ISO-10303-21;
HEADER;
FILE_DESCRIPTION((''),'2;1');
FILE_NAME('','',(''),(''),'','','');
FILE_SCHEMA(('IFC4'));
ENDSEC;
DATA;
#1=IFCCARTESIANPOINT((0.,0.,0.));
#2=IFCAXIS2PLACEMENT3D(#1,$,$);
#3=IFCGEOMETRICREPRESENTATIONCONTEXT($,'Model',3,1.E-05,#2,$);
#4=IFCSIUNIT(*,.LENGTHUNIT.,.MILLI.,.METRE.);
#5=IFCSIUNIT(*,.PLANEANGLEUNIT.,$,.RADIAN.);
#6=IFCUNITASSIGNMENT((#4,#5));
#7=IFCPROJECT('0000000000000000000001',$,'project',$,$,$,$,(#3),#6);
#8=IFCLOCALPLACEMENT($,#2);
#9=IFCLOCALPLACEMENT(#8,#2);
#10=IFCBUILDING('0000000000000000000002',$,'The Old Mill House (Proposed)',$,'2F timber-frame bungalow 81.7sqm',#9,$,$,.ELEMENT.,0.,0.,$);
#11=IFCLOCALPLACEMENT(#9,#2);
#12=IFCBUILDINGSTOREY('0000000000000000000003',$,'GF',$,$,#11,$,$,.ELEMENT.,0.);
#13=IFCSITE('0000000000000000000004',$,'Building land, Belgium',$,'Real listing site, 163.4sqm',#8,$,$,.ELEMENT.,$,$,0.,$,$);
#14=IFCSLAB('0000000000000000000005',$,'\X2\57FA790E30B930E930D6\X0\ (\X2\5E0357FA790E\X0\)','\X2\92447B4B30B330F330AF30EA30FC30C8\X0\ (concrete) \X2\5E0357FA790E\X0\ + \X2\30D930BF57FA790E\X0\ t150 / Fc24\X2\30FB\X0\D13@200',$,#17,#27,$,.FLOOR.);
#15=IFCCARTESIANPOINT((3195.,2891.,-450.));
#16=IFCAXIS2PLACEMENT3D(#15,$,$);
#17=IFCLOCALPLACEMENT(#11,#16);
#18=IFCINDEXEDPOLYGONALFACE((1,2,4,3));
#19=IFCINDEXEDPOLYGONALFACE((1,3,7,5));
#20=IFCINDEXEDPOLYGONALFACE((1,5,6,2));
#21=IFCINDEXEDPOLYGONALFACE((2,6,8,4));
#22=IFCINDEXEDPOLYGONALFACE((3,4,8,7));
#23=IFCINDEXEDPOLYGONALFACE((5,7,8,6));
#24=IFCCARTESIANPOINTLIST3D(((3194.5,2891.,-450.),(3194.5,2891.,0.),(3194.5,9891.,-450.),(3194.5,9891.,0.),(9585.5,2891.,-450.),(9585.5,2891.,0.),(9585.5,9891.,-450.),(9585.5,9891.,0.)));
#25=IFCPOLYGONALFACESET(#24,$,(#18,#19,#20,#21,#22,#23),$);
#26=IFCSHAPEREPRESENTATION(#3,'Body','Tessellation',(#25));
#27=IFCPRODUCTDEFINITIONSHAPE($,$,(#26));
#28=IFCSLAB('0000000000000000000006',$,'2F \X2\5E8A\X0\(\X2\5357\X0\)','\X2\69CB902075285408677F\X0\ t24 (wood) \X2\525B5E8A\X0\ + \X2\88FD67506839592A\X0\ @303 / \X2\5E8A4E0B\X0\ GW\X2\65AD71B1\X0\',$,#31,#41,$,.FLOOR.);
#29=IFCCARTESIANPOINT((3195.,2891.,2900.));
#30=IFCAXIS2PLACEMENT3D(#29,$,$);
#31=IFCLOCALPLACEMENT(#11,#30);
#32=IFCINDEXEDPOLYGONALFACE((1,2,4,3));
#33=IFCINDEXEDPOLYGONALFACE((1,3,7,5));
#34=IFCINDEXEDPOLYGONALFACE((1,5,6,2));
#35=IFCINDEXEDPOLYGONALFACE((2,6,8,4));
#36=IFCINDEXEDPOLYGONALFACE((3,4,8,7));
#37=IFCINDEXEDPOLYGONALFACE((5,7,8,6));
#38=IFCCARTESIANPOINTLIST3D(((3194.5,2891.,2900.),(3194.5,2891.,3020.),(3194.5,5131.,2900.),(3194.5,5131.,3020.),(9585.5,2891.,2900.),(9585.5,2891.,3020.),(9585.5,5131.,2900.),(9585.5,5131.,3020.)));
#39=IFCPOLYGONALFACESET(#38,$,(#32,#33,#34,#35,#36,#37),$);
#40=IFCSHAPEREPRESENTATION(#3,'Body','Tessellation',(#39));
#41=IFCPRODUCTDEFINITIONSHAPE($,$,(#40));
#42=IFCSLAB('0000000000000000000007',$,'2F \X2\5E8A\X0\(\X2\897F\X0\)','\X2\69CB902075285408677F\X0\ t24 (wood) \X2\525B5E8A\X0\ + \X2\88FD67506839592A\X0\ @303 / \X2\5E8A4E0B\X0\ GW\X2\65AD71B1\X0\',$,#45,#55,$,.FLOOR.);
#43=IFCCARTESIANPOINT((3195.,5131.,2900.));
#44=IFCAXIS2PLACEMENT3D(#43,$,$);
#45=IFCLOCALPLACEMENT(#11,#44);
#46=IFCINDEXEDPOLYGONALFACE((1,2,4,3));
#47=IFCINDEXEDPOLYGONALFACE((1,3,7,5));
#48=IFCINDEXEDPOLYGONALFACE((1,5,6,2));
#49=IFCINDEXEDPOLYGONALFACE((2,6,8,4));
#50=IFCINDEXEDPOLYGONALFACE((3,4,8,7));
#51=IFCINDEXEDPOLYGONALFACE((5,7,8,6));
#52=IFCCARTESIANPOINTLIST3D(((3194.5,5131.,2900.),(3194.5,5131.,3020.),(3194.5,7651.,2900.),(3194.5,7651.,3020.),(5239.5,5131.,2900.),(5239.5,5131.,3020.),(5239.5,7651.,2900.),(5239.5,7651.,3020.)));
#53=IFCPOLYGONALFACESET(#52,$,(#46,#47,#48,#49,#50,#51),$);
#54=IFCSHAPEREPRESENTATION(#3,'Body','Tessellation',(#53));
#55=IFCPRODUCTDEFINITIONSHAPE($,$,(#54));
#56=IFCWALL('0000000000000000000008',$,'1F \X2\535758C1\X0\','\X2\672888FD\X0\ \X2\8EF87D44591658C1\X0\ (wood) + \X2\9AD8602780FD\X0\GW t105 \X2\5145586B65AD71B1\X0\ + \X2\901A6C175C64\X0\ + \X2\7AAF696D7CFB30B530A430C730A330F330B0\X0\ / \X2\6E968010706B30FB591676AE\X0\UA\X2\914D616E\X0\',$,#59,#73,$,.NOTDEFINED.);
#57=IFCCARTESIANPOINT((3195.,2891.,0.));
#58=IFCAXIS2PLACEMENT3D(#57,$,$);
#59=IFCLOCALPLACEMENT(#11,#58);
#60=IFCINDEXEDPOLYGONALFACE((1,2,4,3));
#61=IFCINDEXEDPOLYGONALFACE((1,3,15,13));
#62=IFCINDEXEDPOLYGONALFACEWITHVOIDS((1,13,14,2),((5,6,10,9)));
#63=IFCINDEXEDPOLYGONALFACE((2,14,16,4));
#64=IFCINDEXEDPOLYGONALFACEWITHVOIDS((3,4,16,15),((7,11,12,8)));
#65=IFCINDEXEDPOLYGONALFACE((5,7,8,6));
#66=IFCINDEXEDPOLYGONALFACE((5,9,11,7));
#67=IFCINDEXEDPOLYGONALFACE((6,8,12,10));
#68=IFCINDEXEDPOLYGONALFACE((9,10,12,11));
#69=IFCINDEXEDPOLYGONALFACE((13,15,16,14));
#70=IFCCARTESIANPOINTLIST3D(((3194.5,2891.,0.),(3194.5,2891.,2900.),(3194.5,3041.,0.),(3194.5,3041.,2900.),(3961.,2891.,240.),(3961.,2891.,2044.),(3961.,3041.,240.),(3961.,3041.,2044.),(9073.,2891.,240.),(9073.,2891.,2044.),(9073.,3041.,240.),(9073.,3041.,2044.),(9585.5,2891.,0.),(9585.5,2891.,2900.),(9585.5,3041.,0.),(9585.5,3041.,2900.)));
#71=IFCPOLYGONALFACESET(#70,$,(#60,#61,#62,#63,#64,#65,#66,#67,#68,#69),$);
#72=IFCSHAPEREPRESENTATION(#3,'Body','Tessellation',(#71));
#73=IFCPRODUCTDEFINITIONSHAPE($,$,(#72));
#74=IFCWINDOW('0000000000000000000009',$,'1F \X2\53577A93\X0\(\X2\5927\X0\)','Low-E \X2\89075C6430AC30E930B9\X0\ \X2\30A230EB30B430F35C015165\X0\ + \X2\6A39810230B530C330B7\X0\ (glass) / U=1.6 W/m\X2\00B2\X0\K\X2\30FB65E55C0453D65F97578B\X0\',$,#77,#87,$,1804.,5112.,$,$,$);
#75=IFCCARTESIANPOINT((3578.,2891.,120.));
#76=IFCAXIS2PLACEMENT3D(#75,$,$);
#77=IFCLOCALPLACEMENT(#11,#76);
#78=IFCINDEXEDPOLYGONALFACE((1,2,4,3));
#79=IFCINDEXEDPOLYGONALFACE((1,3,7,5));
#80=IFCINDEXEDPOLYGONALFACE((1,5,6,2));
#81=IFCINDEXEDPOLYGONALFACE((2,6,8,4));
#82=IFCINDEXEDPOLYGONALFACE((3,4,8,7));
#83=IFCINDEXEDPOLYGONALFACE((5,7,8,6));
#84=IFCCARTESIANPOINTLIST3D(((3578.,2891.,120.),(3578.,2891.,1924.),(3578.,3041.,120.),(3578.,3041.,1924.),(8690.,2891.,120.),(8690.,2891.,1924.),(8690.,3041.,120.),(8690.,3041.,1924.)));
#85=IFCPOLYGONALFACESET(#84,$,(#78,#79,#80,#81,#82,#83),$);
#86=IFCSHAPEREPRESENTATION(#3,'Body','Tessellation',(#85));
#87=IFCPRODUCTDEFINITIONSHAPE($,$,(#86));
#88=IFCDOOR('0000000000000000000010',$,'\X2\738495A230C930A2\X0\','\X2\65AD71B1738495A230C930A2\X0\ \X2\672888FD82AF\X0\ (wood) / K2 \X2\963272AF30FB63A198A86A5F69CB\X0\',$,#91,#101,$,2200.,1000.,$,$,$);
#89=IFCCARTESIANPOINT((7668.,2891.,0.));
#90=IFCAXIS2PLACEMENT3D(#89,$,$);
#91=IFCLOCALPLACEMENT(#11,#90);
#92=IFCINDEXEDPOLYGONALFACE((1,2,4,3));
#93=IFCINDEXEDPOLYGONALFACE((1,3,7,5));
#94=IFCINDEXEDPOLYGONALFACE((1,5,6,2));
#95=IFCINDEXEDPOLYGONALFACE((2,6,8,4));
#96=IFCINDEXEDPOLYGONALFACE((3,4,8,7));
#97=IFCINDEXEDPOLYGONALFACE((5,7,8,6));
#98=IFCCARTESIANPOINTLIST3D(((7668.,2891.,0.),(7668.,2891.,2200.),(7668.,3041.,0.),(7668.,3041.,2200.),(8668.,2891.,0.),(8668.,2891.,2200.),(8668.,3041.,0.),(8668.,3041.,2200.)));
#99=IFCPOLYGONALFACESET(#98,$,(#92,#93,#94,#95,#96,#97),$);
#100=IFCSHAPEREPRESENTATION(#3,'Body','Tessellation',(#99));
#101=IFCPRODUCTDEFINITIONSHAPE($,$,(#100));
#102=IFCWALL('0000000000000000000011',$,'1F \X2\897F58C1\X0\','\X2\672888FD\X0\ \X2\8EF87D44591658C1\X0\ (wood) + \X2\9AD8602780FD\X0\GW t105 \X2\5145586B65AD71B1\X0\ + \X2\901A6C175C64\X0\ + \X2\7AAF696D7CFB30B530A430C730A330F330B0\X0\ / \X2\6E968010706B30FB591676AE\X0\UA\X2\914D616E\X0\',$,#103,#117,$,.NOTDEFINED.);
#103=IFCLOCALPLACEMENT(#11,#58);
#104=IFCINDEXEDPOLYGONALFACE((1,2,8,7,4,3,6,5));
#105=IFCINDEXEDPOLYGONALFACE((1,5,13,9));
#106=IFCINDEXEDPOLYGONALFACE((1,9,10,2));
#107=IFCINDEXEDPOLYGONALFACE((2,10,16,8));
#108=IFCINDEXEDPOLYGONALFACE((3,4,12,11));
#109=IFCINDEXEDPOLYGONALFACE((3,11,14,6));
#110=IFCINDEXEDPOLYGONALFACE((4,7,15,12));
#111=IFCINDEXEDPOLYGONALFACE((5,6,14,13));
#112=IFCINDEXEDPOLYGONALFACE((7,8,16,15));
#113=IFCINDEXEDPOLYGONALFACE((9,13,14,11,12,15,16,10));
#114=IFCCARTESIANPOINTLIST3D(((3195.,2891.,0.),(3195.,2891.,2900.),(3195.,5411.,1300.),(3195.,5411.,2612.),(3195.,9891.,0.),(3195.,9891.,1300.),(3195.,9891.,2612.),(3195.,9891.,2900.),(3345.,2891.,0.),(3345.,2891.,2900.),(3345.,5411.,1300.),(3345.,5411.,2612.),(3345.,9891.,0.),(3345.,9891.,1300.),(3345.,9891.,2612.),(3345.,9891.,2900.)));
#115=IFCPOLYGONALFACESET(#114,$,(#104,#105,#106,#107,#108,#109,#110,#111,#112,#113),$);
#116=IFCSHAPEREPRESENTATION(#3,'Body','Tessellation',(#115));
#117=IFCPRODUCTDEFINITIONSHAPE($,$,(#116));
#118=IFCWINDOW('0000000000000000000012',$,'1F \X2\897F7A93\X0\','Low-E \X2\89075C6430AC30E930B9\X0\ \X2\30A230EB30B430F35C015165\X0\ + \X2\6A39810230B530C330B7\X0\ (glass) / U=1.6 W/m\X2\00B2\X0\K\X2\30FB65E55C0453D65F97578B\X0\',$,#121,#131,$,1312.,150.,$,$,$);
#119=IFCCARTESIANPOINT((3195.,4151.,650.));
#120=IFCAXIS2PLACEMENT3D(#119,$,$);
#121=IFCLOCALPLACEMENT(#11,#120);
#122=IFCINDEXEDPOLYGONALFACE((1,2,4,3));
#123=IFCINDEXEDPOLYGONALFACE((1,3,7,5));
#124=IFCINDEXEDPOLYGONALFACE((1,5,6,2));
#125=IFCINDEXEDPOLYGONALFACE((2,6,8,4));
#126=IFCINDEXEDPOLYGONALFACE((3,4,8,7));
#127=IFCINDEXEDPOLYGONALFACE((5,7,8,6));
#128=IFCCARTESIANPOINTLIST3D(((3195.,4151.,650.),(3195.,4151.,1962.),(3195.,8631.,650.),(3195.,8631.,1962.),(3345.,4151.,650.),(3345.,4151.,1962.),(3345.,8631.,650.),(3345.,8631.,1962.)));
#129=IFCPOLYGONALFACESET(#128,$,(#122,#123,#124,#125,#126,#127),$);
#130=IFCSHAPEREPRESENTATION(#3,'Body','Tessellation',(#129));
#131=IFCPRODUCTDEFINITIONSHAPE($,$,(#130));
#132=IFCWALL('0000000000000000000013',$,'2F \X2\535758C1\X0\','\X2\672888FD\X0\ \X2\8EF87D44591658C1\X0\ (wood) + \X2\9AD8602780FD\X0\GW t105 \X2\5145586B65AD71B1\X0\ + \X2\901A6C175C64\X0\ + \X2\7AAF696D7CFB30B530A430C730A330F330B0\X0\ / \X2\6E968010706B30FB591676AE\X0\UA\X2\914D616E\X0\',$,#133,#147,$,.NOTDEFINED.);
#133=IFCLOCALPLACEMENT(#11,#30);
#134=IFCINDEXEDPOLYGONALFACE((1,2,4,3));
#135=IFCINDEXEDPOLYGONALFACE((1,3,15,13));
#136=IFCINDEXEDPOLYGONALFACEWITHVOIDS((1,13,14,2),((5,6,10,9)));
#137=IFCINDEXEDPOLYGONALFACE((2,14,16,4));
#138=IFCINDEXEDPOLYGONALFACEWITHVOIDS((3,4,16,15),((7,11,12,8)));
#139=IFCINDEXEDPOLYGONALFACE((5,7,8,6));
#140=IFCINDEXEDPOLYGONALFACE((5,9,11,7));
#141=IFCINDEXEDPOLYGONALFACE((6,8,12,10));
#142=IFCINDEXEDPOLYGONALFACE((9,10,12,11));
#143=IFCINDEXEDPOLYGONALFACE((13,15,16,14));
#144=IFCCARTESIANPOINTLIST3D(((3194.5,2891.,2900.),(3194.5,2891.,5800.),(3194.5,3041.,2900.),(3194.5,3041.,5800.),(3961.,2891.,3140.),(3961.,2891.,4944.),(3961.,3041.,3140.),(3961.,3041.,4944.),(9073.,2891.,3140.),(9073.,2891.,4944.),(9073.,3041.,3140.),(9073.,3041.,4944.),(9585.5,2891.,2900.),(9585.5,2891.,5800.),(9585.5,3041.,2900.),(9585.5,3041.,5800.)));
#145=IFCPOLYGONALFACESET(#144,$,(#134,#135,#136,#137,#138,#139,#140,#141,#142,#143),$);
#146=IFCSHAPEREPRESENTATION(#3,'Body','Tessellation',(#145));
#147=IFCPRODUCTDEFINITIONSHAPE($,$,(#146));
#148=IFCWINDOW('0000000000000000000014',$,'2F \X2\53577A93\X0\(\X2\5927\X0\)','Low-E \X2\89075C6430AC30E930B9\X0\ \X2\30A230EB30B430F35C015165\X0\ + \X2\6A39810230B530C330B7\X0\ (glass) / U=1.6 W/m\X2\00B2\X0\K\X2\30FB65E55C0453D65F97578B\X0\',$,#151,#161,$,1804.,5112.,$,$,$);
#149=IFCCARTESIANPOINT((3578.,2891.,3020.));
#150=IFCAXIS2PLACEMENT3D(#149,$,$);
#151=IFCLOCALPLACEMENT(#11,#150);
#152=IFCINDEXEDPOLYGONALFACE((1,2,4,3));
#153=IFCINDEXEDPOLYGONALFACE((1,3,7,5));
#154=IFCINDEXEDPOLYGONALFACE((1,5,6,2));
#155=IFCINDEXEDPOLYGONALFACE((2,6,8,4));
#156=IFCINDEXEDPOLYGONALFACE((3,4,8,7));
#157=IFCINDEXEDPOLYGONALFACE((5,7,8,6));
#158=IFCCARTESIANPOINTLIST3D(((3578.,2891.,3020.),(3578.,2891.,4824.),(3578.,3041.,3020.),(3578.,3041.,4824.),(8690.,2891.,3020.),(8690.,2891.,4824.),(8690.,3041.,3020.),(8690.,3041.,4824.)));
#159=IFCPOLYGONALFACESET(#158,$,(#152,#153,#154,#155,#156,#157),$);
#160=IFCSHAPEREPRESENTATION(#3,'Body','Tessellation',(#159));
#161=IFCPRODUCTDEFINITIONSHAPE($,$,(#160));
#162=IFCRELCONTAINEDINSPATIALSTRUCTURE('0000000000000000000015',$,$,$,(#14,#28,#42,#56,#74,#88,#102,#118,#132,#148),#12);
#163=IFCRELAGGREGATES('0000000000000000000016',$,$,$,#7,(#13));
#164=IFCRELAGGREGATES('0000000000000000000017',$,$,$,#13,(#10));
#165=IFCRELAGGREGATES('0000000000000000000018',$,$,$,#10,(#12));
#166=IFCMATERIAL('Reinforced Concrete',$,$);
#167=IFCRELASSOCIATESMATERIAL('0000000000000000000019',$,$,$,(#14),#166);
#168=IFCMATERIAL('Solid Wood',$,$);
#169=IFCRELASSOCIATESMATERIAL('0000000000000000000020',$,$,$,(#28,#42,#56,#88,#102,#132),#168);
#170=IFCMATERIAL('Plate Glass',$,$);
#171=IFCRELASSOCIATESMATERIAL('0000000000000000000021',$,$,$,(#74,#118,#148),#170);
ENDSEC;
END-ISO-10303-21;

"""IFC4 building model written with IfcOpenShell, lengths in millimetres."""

from ifc_helpers import new_model, si_unit, frame, frame_2d, origin, place, context, project, spatial, rectangle, extrude, material, element, fill, save


model = new_model("IFC4")

# Units and contexts
model_context = context("Model", 3, precision=1e-05, world=origin())
ifc_project = project(units=[si_unit("LENGTHUNIT", "METRE", prefix="MILLI"), si_unit("PLANEANGLEUNIT", "RADIAN")], contexts=[model_context])

# Site, building, storey
site_placement = place(None, origin())
site = spatial("IfcSite", under=ifc_project, at=site_placement, Name="Building land, Belgium", ObjectType="Real listing site, 163.4sqm", CompositionType="ELEMENT", RefElevation=0.0)
building_placement = place(site_placement, origin())
building = spatial("IfcBuilding", under=site, at=building_placement, Name="The Old Mill House (Proposed)", ObjectType="2F timber-frame bungalow 81.7sqm", CompositionType="ELEMENT", ElevationOfRefHeight=0.0, ElevationOfTerrain=0.0)
storey_placement = place(building_placement, origin())
storey = spatial("IfcBuildingStorey", under=building, at=storey_placement, Name="GF", CompositionType="ELEMENT", Elevation=0.0)

# Slabs
ifc_material_1 = material(Name="Reinforced Concrete")
slab_1_placement = place(storey_placement, frame((3195.0, 2891.0, -450.0)))
element("IfcSlab", 1, at=slab_1_placement, inside=storey, material=ifc_material_1, Name="基礎スラブ (布基礎)", Description="鉄筋コンクリート (concrete) 布基礎 + ベタ基礎 t150 / Fc24・D13@200", PredefinedType="FLOOR", context=model_context, shape_type="SweptSolid", body=[
    extrude(rectangle(XDim=6391.0, YDim=7000.0, at=frame_2d((3195.0, 3500.0))), frame((3195.0, 2891.0, -450.0)), (0.0, 0.0, 1.0), 450.0),
])
ifc_material_2 = material(Name="Solid Wood")
slab_2_placement = place(storey_placement, frame((3195.0, 2891.0, 2900.0)))
element("IfcSlab", 2, at=slab_2_placement, inside=storey, material=ifc_material_2, Name="2F 床(南)", Description="構造用合板 t24 (wood) 剛床 + 製材根太 @303 / 床下 GW断熱", PredefinedType="FLOOR", context=model_context, shape_type="SweptSolid", body=[
    extrude(rectangle(XDim=6391.0, YDim=2240.0, at=frame_2d((3195.0, 1120.0))), frame((3195.0, 2891.0, 2900.0)), (0.0, 0.0, 1.0), 120.0),
])
slab_3_placement = place(storey_placement, frame((3195.0, 5131.0, 2900.0)))
element("IfcSlab", 3, at=slab_3_placement, inside=storey, material=ifc_material_2, Name="2F 床(西)", Description="構造用合板 t24 (wood) 剛床 + 製材根太 @303 / 床下 GW断熱", PredefinedType="FLOOR", context=model_context, shape_type="SweptSolid", body=[
    extrude(rectangle(XDim=2045.0, YDim=2520.0, at=frame_2d((1022.0, 1260.0))), frame((3195.0, 5131.0, 2900.0)), (0.0, 0.0, 1.0), 120.0),
])

# Wall, openings, window, door
wall_1_placement = place(storey_placement, frame((3195.0, 2891.0, 0.0)))
wall_1 = element("IfcWall", 4, at=wall_1_placement, inside=storey, material=ifc_material_2, Name="1F 南壁", Description="木製 軸組外壁 (wood) + 高性能GW t105 充填断熱 + 通気層 + 窯業系サイディング / 準耐火・外皮UA配慮", PredefinedType="NOTDEFINED", context=model_context, shape_type="SweptSolid", body=[
    extrude(rectangle(XDim=6391.0, YDim=150.0, at=frame_2d((3195.0, 75.0))), frame((3195.0, 2891.0, 0.0)), (0.0, 0.0, 1.0), 2900.0),
])
opening_1_placement = place(storey_placement, frame((3578.0, 2891.0, 120.0)))
opening_1 = element("IfcOpeningElement", 5, at=opening_1_placement, cuts=wall_1, PredefinedType="NOTDEFINED", context=model_context, shape_type="SweptSolid", body=[
    extrude(rectangle(XDim=5112.0, YDim=150.0, at=frame_2d((2556.0, 75.0))), frame((3578.0, 2891.0, 120.0)), (0.0, 0.0, 1.0), 1804.0),
])
opening_2_placement = place(storey_placement, frame((7668.0, 2891.0, 0.0)))
opening_2 = element("IfcOpeningElement", 6, at=opening_2_placement, cuts=wall_1, PredefinedType="NOTDEFINED", context=model_context, shape_type="SweptSolid", body=[
    extrude(rectangle(XDim=1000.0, YDim=150.0, at=frame_2d((500.0, 75.0))), frame((7668.0, 2891.0, 0.0)), (0.0, 0.0, 1.0), 2200.0),
])
ifc_material_3 = material(Name="Plate Glass")
window_1_placement = place(storey_placement, frame((3578.0, 2891.0, 120.0)))
window_1 = element("IfcWindow", 7, at=window_1_placement, inside=storey, material=ifc_material_3, Name="1F 南窓(大)", Description="Low-E 複層ガラス アルゴン封入 + 樹脂サッシ (glass) / U=1.6 W/m²K・日射取得型", OverallHeight=1804.0, OverallWidth=5112.0, context=model_context, shape_type="SweptSolid", body=[
    extrude(rectangle(XDim=5112.0, YDim=150.0, at=frame_2d((2556.0, 75.0))), frame((3578.0, 2891.0, 120.0)), (0.0, 0.0, 1.0), 1804.0),
])
fill(opening_1, window_1)
door_placement = place(storey_placement, frame((7668.0, 2891.0, 0.0)))
door = element("IfcDoor", 8, at=door_placement, inside=storey, material=ifc_material_2, Name="玄関ドア", Description="断熱玄関ドア 木製芯 (wood) / K2 防犯・採風機構", OverallHeight=2200.0, OverallWidth=1000.0, context=model_context, shape_type="SweptSolid", body=[
    extrude(rectangle(XDim=1000.0, YDim=150.0, at=frame_2d((500.0, 75.0))), frame((7668.0, 2891.0, 0.0)), (0.0, 0.0, 1.0), 2200.0),
])
fill(opening_2, door)

# Walls, openings, windows
wall_2_placement = place(storey_placement, frame((3195.0, 2891.0, 0.0)))
wall_2 = element("IfcWall", 9, at=wall_2_placement, inside=storey, material=ifc_material_2, Name="1F 西壁", Description="木製 軸組外壁 (wood) + 高性能GW t105 充填断熱 + 通気層 + 窯業系サイディング / 準耐火・外皮UA配慮", PredefinedType="NOTDEFINED", context=model_context, shape_type="SweptSolid", body=[
    extrude(rectangle(XDim=150.0, YDim=7000.0, at=frame_2d((75.0, 3500.0))), frame((3195.0, 2891.0, 0.0)), (0.0, 0.0, 1.0), 2900.0),
])
opening_3_placement = place(storey_placement, frame((3195.0, 4151.0, 650.0)))
opening_3 = element("IfcOpeningElement", 10, at=opening_3_placement, cuts=wall_2, PredefinedType="NOTDEFINED", context=model_context, shape_type="SweptSolid", body=[
    extrude(rectangle(XDim=150.0, YDim=4480.0, at=frame_2d((75.0, 2240.0))), frame((3195.0, 4151.0, 650.0)), (0.0, 0.0, 1.0), 1312.0),
])
window_2_placement = place(storey_placement, frame((3195.0, 4151.0, 650.0)))
window_2 = element("IfcWindow", 11, at=window_2_placement, inside=storey, material=ifc_material_3, Name="1F 西窓", Description="Low-E 複層ガラス アルゴン封入 + 樹脂サッシ (glass) / U=1.6 W/m²K・日射取得型", OverallHeight=1312.0, OverallWidth=150.0, context=model_context, shape_type="SweptSolid", body=[
    extrude(rectangle(XDim=150.0, YDim=4480.0, at=frame_2d((75.0, 2240.0))), frame((3195.0, 4151.0, 650.0)), (0.0, 0.0, 1.0), 1312.0),
])
fill(opening_3, window_2)
wall_3_placement = place(storey_placement, frame((3195.0, 2891.0, 2900.0)))
wall_3 = element("IfcWall", 12, at=wall_3_placement, inside=storey, material=ifc_material_2, Name="2F 南壁", Description="木製 軸組外壁 (wood) + 高性能GW t105 充填断熱 + 通気層 + 窯業系サイディング / 準耐火・外皮UA配慮", PredefinedType="NOTDEFINED", context=model_context, shape_type="SweptSolid", body=[
    extrude(rectangle(XDim=6391.0, YDim=150.0, at=frame_2d((3195.0, 75.0))), frame((3195.0, 2891.0, 2900.0)), (0.0, 0.0, 1.0), 2900.0),
])
opening_4_placement = place(storey_placement, frame((3578.0, 2891.0, 3020.0)))
opening_4 = element("IfcOpeningElement", 13, at=opening_4_placement, cuts=wall_3, PredefinedType="NOTDEFINED", context=model_context, shape_type="SweptSolid", body=[
    extrude(rectangle(XDim=5112.0, YDim=150.0, at=frame_2d((2556.0, 75.0))), frame((3578.0, 2891.0, 3020.0)), (0.0, 0.0, 1.0), 1804.0),
])
window_3_placement = place(storey_placement, frame((3578.0, 2891.0, 3020.0)))
window_3 = element("IfcWindow", 14, at=window_3_placement, inside=storey, material=ifc_material_3, Name="2F 南窓(大)", Description="Low-E 複層ガラス アルゴン封入 + 樹脂サッシ (glass) / U=1.6 W/m²K・日射取得型", OverallHeight=1804.0, OverallWidth=5112.0, context=model_context, shape_type="SweptSolid", body=[
    extrude(rectangle(XDim=5112.0, YDim=150.0, at=frame_2d((2556.0, 75.0))), frame((3578.0, 2891.0, 3020.0)), (0.0, 0.0, 1.0), 1804.0),
])
fill(opening_4, window_3)

save(model, "model.ifc")
